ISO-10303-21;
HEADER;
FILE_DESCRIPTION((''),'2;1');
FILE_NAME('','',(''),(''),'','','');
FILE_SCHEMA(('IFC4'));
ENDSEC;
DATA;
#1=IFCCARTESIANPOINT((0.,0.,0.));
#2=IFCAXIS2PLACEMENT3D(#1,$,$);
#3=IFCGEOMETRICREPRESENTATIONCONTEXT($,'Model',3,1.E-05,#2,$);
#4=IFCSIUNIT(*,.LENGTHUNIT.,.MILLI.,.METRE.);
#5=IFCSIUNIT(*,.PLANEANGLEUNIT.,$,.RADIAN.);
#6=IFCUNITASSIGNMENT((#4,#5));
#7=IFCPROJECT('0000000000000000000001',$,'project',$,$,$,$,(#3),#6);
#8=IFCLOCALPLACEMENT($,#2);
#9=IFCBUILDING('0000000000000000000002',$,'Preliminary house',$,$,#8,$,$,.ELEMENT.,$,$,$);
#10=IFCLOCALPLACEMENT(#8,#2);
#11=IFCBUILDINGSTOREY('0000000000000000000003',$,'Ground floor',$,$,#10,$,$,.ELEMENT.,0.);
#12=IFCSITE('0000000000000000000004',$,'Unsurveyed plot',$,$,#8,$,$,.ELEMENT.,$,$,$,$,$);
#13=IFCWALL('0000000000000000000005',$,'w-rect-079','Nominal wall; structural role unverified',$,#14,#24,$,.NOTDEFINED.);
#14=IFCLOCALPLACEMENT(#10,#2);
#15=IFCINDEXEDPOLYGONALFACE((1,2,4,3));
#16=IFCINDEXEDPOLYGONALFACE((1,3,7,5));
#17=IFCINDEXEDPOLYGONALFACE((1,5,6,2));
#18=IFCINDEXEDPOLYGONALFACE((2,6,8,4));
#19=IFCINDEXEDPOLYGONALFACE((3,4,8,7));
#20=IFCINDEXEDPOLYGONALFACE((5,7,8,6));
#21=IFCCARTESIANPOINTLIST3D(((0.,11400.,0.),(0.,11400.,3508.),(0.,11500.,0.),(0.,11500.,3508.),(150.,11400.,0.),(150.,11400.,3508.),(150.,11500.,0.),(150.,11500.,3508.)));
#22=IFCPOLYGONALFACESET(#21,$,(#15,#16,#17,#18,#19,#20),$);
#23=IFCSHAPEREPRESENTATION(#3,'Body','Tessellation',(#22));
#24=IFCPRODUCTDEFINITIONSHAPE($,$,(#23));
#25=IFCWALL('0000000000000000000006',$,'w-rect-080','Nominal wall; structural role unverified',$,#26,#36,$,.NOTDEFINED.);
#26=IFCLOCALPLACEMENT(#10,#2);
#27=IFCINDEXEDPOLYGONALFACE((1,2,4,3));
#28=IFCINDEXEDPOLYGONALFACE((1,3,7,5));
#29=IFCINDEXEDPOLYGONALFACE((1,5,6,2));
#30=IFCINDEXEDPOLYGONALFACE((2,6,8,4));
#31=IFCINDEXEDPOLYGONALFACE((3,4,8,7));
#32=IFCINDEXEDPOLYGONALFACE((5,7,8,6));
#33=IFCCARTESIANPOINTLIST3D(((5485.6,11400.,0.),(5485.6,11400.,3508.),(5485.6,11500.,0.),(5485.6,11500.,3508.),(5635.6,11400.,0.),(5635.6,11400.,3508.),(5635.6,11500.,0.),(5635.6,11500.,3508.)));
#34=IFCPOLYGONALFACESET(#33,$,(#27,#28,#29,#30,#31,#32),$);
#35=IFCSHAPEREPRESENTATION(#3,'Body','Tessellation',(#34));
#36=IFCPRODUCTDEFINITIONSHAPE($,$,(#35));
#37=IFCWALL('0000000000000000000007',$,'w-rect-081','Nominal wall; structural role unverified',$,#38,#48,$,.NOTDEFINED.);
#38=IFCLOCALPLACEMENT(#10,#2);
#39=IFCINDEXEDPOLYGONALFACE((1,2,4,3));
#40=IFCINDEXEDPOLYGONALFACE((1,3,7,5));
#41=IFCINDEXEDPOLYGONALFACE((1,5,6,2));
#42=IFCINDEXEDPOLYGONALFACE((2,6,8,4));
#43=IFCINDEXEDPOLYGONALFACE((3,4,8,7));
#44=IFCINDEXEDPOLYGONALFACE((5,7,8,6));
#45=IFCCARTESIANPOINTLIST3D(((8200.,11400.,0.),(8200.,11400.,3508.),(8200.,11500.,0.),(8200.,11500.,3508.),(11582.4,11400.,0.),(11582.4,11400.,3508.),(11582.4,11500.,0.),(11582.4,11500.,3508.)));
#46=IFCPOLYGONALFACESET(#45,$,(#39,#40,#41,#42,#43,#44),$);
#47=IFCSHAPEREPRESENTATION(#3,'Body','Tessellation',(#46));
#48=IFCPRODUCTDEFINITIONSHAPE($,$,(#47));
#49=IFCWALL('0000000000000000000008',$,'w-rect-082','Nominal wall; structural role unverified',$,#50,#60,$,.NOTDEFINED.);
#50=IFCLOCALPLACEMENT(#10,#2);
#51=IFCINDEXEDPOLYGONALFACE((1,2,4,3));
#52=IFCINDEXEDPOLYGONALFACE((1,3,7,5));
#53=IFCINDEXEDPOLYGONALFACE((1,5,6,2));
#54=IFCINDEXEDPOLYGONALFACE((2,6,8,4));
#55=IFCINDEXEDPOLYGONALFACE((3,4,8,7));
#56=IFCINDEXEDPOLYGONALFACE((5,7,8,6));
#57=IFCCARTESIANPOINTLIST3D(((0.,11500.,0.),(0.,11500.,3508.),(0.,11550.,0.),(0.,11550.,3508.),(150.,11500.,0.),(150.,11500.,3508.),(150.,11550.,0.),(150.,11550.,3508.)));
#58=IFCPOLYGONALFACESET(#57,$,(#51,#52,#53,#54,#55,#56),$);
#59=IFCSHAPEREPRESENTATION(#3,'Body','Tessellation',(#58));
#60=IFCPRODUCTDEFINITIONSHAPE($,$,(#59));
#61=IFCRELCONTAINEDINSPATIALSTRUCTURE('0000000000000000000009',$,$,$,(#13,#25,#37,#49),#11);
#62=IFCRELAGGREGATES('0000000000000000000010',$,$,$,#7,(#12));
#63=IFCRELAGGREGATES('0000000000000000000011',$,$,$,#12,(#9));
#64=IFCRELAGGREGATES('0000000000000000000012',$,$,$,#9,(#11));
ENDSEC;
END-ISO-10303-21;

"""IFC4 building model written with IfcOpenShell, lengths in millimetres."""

from ifc_helpers import new_model, si_unit, origin, place, context, project, spatial, polyline, outline, extrude, element, save


model = new_model("IFC4")

# Units and contexts
model_context = context("Model", 3, precision=1e-05, world=origin())
ifc_project = project(units=[si_unit("LENGTHUNIT", "METRE", prefix="MILLI"), si_unit("PLANEANGLEUNIT", "RADIAN")], contexts=[model_context])

# Site, building, storey
placement_1 = place(None, origin())
site = spatial("IfcSite", under=ifc_project, at=placement_1, Name="Unsurveyed plot", CompositionType="ELEMENT")
building = spatial("IfcBuilding", under=site, at=placement_1, Name="Preliminary house", CompositionType="ELEMENT")
placement_2 = place(placement_1, origin())
storey = spatial("IfcBuildingStorey", under=building, at=placement_2, Name="Ground floor", CompositionType="ELEMENT", Elevation=0.0)

# Walls
element("IfcWall", 1, at=placement_2, inside=storey, Name="w-rect-079", Description="Nominal wall; structural role unverified", PredefinedType="NOTDEFINED", context=model_context, shape_type="SweptSolid", body=[
    extrude(outline(polyline([(0.0, 11400.0), (150.0, 11400.0), (150.0, 11500.0), (0.0, 11500.0), (0.0, 11400.0)])), origin(), (0.0, 0.0, 1.0), 3508.0),
])
element("IfcWall", 2, at=placement_2, inside=storey, Name="w-rect-080", Description="Nominal wall; structural role unverified", PredefinedType="NOTDEFINED", context=model_context, shape_type="SweptSolid", body=[
    extrude(outline(polyline([(5485.6, 11400.0), (5635.6, 11400.0), (5635.6, 11500.0), (5485.6, 11500.0), (5485.6, 11400.0)])), origin(), (0.0, 0.0, 1.0), 3508.0),
])
element("IfcWall", 3, at=placement_2, inside=storey, Name="w-rect-081", Description="Nominal wall; structural role unverified", PredefinedType="NOTDEFINED", context=model_context, shape_type="SweptSolid", body=[
    extrude(outline(polyline([(8200.0, 11400.0), (11582.4, 11400.0), (11582.4, 11500.0), (8200.0, 11500.0), (8200.0, 11400.0)])), origin(), (0.0, 0.0, 1.0), 3508.0),
])
element("IfcWall", 4, at=placement_2, inside=storey, Name="w-rect-082", Description="Nominal wall; structural role unverified", PredefinedType="NOTDEFINED", context=model_context, shape_type="SweptSolid", body=[
    extrude(outline(polyline([(0.0, 11500.0), (150.0, 11500.0), (150.0, 11550.0), (0.0, 11550.0), (0.0, 11500.0)])), origin(), (0.0, 0.0, 1.0), 3508.0),
])

save(model, "model.ifc")
